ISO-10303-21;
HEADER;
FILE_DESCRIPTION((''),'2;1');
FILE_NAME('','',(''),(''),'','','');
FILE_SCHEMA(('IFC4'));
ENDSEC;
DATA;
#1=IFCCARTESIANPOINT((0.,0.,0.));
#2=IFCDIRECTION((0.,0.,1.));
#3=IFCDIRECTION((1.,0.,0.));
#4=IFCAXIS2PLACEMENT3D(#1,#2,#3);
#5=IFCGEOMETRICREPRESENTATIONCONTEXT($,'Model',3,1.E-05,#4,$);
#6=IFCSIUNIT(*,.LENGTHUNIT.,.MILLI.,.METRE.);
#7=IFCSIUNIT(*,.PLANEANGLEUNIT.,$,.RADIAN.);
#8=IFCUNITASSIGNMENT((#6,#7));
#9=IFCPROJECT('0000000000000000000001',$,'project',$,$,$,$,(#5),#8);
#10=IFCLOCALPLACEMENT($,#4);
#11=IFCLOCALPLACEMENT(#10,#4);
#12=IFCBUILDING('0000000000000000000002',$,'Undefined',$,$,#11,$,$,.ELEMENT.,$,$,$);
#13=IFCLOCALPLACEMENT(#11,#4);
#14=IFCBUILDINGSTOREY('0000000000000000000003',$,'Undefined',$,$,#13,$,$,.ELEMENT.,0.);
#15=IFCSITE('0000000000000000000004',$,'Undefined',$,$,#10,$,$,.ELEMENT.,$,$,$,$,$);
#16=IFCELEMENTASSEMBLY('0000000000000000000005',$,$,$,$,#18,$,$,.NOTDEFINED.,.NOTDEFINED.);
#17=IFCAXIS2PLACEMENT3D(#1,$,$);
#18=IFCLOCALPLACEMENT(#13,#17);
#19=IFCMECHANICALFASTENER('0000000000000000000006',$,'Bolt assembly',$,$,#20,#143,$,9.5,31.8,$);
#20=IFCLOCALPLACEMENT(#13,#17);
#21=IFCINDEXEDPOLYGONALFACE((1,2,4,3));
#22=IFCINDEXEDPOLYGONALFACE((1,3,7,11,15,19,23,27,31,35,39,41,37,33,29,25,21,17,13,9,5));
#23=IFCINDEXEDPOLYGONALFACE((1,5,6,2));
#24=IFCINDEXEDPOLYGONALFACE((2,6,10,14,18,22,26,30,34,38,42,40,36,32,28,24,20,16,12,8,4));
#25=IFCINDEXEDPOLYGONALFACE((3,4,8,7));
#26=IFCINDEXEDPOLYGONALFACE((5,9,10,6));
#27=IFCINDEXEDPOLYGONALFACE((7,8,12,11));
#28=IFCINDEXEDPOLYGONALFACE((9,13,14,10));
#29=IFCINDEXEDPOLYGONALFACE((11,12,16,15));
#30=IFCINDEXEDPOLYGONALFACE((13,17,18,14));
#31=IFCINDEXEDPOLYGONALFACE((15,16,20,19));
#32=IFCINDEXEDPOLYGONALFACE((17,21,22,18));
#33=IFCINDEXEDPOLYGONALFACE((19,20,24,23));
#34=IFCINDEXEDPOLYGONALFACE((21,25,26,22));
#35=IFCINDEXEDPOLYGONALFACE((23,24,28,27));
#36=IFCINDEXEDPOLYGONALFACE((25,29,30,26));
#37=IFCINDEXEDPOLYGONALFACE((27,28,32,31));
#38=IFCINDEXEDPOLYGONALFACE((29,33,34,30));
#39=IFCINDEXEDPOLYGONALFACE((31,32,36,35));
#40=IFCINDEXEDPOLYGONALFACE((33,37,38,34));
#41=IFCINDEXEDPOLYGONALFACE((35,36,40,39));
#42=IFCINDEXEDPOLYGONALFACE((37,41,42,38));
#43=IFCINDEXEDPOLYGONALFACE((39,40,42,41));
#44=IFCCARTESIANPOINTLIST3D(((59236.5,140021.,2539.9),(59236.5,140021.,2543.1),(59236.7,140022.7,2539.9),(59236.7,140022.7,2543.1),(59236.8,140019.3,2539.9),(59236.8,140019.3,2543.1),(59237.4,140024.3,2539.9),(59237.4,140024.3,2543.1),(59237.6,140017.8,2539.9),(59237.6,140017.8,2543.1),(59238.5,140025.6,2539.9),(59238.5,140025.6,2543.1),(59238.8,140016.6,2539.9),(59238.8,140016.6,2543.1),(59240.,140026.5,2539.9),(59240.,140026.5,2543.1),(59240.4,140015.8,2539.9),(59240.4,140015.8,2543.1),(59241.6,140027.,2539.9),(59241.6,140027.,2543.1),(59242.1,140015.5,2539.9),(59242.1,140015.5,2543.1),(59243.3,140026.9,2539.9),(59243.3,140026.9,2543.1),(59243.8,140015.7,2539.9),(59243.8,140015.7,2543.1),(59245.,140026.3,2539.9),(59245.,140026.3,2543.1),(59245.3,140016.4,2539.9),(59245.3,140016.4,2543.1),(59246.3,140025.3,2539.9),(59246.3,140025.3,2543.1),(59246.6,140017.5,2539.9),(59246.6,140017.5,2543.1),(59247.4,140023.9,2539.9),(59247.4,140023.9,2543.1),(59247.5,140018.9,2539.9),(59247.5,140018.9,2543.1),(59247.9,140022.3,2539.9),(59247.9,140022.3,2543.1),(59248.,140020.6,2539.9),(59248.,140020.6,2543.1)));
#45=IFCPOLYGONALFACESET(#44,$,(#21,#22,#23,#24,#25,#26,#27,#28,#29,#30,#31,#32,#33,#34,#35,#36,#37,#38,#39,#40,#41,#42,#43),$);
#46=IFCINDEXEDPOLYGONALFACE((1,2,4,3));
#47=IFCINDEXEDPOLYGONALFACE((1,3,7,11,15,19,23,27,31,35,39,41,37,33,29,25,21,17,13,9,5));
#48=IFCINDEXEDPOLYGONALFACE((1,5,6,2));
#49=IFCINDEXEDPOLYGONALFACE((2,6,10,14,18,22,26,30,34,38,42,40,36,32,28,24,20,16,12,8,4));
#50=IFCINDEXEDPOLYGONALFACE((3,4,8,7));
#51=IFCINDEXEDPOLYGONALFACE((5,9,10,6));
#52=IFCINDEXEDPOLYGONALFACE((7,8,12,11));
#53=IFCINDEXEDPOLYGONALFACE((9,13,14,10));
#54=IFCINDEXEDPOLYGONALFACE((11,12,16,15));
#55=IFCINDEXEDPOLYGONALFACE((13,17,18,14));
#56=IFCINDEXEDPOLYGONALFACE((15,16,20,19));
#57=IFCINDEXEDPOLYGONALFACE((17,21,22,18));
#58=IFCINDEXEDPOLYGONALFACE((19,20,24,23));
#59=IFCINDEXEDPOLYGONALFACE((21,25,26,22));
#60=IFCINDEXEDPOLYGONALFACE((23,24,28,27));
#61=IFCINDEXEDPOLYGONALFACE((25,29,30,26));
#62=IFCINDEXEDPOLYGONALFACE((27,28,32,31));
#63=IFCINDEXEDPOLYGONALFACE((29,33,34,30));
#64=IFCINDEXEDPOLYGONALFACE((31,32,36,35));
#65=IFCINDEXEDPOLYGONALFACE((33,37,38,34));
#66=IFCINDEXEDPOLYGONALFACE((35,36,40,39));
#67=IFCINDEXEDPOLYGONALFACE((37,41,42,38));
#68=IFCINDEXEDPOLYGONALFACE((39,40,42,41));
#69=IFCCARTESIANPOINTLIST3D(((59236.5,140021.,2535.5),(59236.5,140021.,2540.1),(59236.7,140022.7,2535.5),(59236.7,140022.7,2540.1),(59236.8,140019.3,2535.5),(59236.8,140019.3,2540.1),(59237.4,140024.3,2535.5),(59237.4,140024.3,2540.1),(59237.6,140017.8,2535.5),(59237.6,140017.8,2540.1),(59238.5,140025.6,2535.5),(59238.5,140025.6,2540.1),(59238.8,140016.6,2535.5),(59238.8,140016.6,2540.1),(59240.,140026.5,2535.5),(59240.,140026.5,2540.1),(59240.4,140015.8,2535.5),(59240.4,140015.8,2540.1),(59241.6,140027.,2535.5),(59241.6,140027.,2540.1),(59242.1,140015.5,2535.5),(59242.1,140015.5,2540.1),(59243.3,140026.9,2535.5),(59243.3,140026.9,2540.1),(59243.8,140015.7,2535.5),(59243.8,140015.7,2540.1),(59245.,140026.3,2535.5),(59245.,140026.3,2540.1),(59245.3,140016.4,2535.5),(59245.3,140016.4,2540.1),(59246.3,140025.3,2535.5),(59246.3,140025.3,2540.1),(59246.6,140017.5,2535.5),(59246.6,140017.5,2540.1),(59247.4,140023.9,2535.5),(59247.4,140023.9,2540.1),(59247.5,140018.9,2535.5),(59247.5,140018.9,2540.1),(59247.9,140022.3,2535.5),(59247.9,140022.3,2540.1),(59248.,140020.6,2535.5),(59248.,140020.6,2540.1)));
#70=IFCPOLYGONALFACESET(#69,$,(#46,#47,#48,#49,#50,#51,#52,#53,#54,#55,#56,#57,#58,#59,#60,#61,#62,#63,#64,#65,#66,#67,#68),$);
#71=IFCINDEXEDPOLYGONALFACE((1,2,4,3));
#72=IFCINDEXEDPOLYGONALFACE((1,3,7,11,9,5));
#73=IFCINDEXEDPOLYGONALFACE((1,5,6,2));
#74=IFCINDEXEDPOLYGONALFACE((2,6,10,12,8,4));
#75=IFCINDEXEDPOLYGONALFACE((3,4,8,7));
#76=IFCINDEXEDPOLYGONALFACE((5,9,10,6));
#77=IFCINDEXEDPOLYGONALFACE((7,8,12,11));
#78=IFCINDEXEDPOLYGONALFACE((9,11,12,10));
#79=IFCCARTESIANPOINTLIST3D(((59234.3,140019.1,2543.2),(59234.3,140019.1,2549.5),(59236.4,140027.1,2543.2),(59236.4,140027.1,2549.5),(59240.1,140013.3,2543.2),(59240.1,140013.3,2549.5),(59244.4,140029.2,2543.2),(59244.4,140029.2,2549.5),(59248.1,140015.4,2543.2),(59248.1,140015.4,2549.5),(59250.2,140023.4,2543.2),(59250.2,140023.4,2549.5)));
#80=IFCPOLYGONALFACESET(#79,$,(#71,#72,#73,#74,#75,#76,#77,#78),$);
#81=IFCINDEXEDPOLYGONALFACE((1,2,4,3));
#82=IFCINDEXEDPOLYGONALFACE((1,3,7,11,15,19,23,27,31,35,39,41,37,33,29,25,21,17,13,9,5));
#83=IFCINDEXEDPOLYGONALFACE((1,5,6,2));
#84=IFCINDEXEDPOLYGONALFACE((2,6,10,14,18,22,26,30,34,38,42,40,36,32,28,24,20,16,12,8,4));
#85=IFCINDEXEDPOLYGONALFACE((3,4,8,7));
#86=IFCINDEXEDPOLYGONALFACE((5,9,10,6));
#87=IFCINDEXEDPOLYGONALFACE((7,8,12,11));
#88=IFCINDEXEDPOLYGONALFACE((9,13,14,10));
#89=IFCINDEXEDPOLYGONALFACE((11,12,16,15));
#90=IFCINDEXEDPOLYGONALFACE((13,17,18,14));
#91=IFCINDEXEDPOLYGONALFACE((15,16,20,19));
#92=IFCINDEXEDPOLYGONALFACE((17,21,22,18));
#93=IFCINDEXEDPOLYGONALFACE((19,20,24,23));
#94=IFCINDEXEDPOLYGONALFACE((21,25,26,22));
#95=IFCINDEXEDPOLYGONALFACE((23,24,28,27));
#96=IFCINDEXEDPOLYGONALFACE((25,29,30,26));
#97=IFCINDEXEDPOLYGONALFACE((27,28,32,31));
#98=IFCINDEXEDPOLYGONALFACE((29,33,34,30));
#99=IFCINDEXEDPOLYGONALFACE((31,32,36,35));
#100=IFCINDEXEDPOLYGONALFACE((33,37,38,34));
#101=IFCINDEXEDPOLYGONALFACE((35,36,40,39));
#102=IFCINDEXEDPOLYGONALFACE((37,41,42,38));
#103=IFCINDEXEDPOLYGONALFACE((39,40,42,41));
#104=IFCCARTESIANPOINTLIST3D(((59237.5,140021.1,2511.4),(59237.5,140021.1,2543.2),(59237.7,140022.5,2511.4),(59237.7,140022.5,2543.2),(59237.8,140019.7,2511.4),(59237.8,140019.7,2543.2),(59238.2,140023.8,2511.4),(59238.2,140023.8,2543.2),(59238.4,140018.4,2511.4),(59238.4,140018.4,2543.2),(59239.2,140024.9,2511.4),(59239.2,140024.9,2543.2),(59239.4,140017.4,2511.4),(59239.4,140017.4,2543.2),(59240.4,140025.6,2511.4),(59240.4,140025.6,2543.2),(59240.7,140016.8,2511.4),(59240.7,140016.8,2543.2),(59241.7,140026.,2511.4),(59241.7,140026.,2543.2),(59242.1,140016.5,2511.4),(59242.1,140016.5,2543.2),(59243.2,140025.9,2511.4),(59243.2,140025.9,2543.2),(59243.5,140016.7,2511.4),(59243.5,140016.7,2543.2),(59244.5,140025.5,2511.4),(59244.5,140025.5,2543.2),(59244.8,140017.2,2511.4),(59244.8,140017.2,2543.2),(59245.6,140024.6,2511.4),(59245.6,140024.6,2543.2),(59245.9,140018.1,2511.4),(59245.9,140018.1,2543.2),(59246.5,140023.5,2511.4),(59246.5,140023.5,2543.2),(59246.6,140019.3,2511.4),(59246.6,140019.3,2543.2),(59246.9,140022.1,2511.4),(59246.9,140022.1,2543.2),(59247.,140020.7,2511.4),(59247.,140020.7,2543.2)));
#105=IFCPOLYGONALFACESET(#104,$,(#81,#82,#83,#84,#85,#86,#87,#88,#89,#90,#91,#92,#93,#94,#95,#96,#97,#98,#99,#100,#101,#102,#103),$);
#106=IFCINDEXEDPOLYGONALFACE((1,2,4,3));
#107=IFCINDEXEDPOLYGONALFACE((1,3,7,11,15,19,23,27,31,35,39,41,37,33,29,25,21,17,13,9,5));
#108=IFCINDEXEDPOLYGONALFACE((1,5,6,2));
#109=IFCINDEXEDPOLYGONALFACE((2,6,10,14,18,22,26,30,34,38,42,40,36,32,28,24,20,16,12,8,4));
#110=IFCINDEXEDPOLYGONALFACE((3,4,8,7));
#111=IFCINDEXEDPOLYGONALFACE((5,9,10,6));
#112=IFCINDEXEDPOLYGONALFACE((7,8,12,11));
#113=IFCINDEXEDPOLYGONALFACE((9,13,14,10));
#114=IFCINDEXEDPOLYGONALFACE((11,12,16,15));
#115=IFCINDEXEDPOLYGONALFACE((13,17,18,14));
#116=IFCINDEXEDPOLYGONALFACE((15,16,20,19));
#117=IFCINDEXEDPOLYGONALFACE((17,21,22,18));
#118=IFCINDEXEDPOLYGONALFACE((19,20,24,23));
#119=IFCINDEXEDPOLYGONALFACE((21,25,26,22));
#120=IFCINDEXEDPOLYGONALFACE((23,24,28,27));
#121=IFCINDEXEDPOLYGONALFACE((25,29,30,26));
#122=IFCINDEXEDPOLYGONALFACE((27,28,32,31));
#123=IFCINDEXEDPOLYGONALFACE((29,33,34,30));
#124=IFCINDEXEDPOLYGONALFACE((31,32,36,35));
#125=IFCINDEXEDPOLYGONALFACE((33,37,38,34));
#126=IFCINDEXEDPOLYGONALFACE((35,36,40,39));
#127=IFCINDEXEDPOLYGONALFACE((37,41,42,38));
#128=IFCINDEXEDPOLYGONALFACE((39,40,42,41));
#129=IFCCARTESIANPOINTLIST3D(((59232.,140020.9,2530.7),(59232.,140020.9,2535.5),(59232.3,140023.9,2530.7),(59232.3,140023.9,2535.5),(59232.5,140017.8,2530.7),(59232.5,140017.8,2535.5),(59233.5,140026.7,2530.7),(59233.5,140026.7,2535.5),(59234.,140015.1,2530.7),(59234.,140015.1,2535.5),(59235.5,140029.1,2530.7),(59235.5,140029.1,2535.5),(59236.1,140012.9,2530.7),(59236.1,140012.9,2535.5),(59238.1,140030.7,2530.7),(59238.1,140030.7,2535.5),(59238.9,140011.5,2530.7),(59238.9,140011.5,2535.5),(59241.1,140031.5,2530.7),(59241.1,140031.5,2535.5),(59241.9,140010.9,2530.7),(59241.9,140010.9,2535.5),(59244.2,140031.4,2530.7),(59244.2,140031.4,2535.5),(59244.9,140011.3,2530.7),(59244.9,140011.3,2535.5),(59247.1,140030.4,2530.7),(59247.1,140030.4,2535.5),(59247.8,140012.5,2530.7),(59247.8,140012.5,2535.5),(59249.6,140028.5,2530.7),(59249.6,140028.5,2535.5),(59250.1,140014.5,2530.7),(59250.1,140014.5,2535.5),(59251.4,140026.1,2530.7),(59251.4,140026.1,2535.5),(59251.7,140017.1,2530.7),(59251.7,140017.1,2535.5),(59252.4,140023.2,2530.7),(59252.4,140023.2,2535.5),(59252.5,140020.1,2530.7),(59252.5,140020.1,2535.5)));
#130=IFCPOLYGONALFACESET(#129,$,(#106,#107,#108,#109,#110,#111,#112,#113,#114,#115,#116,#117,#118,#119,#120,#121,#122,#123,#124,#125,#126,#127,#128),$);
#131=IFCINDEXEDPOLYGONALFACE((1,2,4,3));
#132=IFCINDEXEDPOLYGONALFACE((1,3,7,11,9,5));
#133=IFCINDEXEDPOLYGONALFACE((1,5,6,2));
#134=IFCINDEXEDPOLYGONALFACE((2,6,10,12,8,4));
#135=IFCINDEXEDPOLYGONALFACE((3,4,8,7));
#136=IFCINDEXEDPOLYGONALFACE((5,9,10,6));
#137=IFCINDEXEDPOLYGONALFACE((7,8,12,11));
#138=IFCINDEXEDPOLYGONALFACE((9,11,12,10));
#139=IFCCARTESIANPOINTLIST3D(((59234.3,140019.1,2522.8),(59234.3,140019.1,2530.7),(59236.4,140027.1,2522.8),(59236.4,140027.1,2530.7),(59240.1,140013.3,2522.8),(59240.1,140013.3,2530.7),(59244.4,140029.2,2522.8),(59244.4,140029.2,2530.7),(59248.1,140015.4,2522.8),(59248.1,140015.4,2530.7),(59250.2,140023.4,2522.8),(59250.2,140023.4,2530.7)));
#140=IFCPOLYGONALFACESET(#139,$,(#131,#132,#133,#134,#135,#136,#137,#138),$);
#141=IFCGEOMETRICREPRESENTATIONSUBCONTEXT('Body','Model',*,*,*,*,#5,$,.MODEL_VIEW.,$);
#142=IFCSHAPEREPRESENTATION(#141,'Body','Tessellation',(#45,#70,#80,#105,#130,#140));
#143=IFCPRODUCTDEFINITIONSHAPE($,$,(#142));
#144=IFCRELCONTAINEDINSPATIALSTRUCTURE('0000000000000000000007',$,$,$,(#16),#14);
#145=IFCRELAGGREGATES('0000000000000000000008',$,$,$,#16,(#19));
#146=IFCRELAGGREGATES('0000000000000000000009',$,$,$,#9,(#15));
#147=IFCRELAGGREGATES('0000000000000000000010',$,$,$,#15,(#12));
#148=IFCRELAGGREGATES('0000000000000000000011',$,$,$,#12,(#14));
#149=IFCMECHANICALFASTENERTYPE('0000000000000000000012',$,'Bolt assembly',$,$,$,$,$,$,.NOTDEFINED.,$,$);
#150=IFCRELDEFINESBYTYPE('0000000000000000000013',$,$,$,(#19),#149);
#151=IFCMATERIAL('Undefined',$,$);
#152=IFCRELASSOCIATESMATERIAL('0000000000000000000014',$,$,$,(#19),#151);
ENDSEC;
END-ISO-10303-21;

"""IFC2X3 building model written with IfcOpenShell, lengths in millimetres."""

from ifc_helpers import new_model, si_unit, frame, origin_with_axes, origin_2d_with_axis, place, context, subcontext, project, spatial, polyline, circle, outline, extrude, source, transform, mapped, material, type_object, element, aggregate, save


model = new_model("IFC2X3")

# Units and contexts
model_context = context("Model", 3, precision=1e-05, world=origin_with_axes())
body_context = subcontext(model_context, "Body", "Model", "MODEL_VIEW")
ifc_project = project(units=[si_unit("LENGTHUNIT", "METRE", prefix="MILLI"), si_unit("PLANEANGLEUNIT", "RADIAN")], contexts=[model_context])

# Site, building, storey
site_placement = place(None, origin_with_axes())
site = spatial("IfcSite", under=ifc_project, at=site_placement, Name="Undefined", CompositionType="ELEMENT")
building_placement = place(site_placement, origin_with_axes())
building = spatial("IfcBuilding", under=site, at=building_placement, Name="Undefined", CompositionType="ELEMENT")
storey_placement = place(building_placement, origin_with_axes())
storey = spatial("IfcBuildingStorey", under=building, at=storey_placement, Name="Undefined", CompositionType="ELEMENT", Elevation=0.0)

# Element assembly
assembly_1_placement = place(storey_placement, origin_with_axes())
assembly_1 = element("IfcElementAssembly", 1, at=assembly_1_placement, inside=storey, AssemblyPlace="NOTDEFINED", PredefinedType="NOTDEFINED")

# Mechanical fastener
ifc_material_1 = material(Name="Undefined")
mechanical_fastener_type = type_object("IfcMechanicalFastenerType", Name="Bolt assembly")
shared_shape_1 = source(origin_with_axes(), body_context, "Body", "SweptSolid", [
    extrude(circle(Radius=5.8, at=origin_2d_with_axis()), frame((0.0, -7.6, 0.0), z_axis=(0.0, 1.0, 0.0), x_axis=(1.0, 0.0, 0.0)), (0.0, 0.0, 1.0), 3.2),
    extrude(circle(Radius=5.8, at=origin_2d_with_axis()), frame((0.0, -4.6, 0.0), z_axis=(0.0, 1.0, 0.0), x_axis=(1.0, 0.0, 0.0)), (0.0, 0.0, 1.0), 4.6),
    extrude(outline(polyline([(7.1, -4.1), (7.1, 4.1), (0.0, 8.2), (-7.1, 4.1), (-7.1, -4.1), (0.0, -8.2), (7.1, -4.1)])), frame((0.0, -14.0, 0.0), z_axis=(0.0, 1.0, 0.0), x_axis=(1.0, 0.0, 0.0)), (0.0, 0.0, 1.0), 6.3),
    extrude(circle(Radius=4.8, at=origin_2d_with_axis()), frame((0.0, -7.7, 0.0), z_axis=(0.0, 1.0, 0.0), x_axis=(1.0, 0.0, 0.0)), (0.0, 0.0, 1.0), 31.8),
    extrude(circle(Radius=10.3, at=origin_2d_with_axis()), frame((0.0, 0.0, 0.0), z_axis=(0.0, 1.0, 0.0), x_axis=(1.0, 0.0, 0.0)), (0.0, 0.0, 1.0), 4.8),
    extrude(outline(polyline([(7.1, -4.1), (7.1, 4.1), (0.0, 8.2), (-7.1, 4.1), (-7.1, -4.1), (0.0, -8.2), (7.1, -4.1)])), frame((0.0, 4.8, 0.0), z_axis=(0.0, 1.0, 0.0), x_axis=(1.0, 0.0, 0.0)), (0.0, 0.0, 1.0), 7.9),
])
mechanical_fastener_1_placement = place(assembly_1_placement, frame((59242.3, 140021.3, 2535.5), z_axis=(-0.707107, 0.707107, 0.0), x_axis=(0.707107, 0.707107, 0.0)))
mechanical_fastener_1 = element("IfcMechanicalFastener", 2, at=mechanical_fastener_1_placement, type_object=mechanical_fastener_type, material=ifc_material_1, Name="Bolt assembly", NominalDiameter=9.5, NominalLength=31.8, context=body_context, shape_type="MappedRepresentation", body=[
    mapped(shared_shape_1, transform((0.0, 0.0, 0.0))),
])
aggregate(assembly_1, [mechanical_fastener_1])

save(model, "model.ifc")
